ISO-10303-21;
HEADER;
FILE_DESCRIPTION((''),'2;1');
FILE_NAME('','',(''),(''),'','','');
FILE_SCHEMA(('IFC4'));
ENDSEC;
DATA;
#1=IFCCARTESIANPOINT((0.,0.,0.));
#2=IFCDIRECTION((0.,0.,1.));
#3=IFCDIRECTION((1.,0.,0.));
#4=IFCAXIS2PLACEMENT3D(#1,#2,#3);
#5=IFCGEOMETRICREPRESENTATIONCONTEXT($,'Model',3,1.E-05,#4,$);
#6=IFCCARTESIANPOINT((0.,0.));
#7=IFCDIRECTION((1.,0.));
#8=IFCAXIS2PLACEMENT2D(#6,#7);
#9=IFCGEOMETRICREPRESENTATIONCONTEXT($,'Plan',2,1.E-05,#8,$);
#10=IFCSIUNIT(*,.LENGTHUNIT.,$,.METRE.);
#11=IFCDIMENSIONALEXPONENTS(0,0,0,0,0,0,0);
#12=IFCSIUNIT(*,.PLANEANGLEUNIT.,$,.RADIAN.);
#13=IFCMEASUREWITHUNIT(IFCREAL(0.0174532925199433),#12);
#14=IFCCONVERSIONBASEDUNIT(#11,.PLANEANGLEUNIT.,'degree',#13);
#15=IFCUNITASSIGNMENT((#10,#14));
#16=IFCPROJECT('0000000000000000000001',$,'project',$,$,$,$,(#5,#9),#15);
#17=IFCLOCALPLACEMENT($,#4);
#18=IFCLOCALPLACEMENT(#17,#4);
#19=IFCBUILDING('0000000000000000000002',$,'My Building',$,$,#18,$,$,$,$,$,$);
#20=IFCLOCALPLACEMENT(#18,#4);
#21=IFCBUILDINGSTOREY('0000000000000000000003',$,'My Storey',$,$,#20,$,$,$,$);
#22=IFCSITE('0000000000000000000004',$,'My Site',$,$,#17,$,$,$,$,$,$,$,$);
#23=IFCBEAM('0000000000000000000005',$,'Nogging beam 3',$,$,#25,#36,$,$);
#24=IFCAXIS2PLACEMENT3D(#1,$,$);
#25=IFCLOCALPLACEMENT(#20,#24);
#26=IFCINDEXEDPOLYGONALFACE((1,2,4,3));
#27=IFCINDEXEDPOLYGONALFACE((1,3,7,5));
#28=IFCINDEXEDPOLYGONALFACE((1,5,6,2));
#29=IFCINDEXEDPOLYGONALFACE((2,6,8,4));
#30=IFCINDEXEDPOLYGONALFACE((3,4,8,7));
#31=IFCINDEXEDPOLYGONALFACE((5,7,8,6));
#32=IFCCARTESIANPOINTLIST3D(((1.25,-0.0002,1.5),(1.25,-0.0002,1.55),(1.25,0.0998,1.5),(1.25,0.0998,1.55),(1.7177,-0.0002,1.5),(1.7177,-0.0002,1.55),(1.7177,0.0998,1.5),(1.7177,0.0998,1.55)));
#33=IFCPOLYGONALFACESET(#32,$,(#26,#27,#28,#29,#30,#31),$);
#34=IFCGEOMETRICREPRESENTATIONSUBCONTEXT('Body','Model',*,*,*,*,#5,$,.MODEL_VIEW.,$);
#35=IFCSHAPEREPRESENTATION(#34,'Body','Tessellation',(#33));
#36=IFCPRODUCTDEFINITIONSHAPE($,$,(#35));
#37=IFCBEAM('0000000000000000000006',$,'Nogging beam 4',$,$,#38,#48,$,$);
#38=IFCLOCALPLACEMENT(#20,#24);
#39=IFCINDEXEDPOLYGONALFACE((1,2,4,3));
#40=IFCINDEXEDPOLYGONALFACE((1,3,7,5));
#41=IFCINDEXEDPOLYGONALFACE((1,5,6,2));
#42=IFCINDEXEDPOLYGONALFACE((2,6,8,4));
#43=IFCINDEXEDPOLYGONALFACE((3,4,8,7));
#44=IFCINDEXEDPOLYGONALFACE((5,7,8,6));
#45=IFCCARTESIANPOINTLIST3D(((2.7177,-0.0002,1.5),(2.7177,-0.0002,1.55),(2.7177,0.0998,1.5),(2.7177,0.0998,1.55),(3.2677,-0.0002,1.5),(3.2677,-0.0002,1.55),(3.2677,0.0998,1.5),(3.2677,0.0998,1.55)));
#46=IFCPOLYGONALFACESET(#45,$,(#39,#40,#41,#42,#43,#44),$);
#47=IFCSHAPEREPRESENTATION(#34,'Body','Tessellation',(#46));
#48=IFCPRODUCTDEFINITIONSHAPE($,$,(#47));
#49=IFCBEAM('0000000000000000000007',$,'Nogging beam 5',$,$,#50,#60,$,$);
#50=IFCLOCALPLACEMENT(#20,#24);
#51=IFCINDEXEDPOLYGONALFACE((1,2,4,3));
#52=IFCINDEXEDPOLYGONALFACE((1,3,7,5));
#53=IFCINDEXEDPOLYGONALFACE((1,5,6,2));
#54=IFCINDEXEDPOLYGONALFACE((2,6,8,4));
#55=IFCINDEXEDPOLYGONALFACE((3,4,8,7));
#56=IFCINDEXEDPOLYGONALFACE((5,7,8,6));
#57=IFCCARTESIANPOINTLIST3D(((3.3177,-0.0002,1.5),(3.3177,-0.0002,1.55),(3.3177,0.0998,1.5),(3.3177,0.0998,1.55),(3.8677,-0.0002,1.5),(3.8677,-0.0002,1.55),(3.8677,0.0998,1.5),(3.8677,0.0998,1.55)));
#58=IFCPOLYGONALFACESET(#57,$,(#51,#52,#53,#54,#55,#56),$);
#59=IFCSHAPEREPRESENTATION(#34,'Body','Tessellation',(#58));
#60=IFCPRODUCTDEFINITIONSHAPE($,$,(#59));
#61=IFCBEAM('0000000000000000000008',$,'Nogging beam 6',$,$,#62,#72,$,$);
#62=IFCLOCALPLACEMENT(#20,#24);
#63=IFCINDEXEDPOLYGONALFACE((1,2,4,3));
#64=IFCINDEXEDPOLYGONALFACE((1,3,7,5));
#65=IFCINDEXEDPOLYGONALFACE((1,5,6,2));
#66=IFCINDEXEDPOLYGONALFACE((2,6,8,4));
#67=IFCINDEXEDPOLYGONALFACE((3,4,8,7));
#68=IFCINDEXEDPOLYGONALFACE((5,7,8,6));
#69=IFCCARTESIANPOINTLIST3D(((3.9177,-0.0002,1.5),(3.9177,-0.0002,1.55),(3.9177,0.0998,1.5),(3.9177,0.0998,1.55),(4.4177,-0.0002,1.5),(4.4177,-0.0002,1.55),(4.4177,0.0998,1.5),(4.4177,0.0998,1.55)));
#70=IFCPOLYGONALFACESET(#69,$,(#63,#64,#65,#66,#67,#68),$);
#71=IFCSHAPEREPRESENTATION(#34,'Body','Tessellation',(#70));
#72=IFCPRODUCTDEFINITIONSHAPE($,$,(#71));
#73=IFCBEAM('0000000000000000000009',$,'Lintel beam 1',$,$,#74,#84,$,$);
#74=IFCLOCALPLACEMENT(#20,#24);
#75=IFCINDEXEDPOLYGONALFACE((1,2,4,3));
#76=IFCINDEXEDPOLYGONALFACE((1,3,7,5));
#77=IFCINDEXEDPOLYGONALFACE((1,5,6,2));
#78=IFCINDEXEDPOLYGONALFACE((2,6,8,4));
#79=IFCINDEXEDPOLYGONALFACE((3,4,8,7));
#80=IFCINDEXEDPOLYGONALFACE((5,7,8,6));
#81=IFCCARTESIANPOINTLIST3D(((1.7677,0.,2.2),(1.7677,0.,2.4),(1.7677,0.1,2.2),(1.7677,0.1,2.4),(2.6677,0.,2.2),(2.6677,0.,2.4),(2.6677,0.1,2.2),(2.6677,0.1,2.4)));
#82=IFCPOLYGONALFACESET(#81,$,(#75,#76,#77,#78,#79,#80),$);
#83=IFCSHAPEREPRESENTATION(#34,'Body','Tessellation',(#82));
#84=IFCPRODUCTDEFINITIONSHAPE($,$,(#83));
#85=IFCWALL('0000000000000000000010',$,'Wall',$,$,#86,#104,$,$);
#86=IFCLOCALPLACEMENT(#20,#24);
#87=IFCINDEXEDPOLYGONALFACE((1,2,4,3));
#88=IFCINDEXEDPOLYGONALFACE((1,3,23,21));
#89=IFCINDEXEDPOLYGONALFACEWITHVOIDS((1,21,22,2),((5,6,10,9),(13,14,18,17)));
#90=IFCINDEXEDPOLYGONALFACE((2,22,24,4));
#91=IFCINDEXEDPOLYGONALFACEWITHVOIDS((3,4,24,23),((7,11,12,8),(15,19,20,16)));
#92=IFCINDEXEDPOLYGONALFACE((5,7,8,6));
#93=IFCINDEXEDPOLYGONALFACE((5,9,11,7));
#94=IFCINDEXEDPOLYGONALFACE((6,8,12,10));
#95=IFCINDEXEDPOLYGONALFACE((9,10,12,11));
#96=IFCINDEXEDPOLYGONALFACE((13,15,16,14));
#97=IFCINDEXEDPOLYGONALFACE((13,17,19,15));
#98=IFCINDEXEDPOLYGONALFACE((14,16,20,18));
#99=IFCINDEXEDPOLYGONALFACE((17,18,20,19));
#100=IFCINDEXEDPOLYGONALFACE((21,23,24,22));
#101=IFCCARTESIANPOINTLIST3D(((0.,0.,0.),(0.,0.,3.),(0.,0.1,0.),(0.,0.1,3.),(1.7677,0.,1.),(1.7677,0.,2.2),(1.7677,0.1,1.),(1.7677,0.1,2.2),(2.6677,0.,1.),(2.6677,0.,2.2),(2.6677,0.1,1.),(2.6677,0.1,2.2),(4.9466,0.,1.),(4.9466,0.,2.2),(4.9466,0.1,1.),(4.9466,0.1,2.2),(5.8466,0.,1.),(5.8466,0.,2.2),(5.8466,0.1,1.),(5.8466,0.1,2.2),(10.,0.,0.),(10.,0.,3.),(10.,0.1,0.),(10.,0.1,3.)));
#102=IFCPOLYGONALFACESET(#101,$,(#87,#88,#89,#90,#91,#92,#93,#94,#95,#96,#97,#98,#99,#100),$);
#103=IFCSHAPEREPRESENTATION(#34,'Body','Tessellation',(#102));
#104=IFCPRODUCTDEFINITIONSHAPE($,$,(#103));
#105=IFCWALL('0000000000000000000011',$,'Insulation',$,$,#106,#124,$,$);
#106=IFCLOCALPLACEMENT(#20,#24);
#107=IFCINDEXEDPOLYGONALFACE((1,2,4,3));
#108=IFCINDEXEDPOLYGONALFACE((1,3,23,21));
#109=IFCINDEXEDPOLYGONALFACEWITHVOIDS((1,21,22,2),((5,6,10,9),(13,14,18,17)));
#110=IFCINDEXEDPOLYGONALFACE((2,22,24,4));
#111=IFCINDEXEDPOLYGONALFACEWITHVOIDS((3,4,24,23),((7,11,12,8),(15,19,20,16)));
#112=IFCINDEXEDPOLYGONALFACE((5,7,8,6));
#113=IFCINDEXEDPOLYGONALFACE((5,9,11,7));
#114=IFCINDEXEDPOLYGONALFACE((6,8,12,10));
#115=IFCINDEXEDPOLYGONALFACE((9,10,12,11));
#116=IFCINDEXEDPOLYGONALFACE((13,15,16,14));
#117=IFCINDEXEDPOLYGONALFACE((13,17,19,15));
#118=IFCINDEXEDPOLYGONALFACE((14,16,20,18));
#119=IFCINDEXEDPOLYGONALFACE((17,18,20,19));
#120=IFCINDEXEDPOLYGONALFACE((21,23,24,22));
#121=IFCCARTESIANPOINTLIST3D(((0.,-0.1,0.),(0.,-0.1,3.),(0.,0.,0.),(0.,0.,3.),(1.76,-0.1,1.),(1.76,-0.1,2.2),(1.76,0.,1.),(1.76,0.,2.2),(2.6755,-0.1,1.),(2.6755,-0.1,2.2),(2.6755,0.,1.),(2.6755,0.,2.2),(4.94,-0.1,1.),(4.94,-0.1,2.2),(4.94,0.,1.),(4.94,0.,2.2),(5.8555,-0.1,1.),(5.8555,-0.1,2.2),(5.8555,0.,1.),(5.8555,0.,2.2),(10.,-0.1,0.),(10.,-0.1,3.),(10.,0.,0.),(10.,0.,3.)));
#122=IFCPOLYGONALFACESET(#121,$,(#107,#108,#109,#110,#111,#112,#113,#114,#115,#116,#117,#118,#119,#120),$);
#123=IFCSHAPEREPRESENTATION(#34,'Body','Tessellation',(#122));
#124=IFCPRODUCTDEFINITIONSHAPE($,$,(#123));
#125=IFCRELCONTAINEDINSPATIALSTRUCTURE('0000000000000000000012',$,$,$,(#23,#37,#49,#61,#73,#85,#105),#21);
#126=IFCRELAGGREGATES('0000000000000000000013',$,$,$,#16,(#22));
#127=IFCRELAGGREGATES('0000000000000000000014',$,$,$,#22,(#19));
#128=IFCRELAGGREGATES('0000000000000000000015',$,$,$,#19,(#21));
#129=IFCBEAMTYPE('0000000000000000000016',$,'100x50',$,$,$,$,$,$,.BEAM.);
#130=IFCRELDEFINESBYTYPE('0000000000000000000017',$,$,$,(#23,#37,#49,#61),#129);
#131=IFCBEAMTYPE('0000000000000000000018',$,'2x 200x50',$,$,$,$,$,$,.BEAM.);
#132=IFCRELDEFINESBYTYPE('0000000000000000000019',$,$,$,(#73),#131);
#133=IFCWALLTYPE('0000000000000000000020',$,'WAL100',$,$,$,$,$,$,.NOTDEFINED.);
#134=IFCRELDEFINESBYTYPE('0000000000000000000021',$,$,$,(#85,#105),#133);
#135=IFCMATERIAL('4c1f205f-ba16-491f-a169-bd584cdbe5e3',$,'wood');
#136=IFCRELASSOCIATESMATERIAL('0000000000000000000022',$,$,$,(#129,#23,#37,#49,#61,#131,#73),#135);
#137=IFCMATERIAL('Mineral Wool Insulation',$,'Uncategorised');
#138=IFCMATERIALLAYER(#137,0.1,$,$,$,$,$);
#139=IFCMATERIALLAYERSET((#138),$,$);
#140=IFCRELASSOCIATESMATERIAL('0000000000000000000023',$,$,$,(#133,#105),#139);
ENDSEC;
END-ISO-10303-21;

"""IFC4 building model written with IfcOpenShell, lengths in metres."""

from ifc_helpers import new_model, entity, si_unit, converted_unit, frame, origin_with_axes, origin_2d_with_axis, place, context, subcontext, project, spatial, line, indexed_curve, outline, extrude, source, transform, mapped, material, layer, layer_set, layer_usage, material_profile, profile_set, profile_usage, type_object, element, save


model = new_model("IFC4")

# Units and contexts
model_context = context("Model", 3, precision=1e-05, world=origin_with_axes())
plan_context = context("Plan", 2, precision=1e-05, world=origin_2d_with_axis())
body_context = subcontext(model_context, "Body", "Model", "MODEL_VIEW")
ifc_project = project(units=[si_unit("LENGTHUNIT", "METRE"), converted_unit("PLANEANGLEUNIT", "degree", entity("IfcReal", 0.0174532925199433), si_unit("PLANEANGLEUNIT", "RADIAN"), dimensions=[0, 0, 0, 0, 0, 0, 0])], contexts=[model_context, plan_context])

# Site, building, storey
site_placement = place(None, origin_with_axes())
site = spatial("IfcSite", under=ifc_project, at=site_placement, Name="My Site")
building_placement = place(site_placement, origin_with_axes())
building = spatial("IfcBuilding", under=site, at=building_placement, Name="My Building")
storey_placement = place(building_placement, origin_with_axes())
storey = spatial("IfcBuildingStorey", under=building, at=storey_placement, Name="My Storey")

# Shared definitions
ifc_material_1 = material(Name="4c1f205f-ba16-491f-a169-bd584cdbe5e3", Category="wood")

# Beams
ifc_material_profile_1 = material_profile(ifc_material_1, outline(indexed_curve([(-0.05, 0.025), (0.05, 0.025), (0.05, -0.025), (-0.05, -0.025), (-0.05, 0.025)])))
ifc_profile_set_1 = profile_set([ifc_material_profile_1])
beam_type_1 = type_object("IfcBeamType", Name="100x50", PredefinedType="BEAM", material=ifc_profile_set_1)
ifc_profile_usage_1 = profile_usage(ifc_profile_set_1, cardinal=5)
beam_1_placement = place(storey_placement, frame((1.25, 0.0498, 1.525), z_axis=(1.0, -0.000001, 0.000001), x_axis=(0.000001, 1.0, 0.0)))
element("IfcBeam", 1, at=beam_1_placement, inside=storey, type_object=beam_type_1, material=ifc_profile_usage_1, Name="Nogging beam 3", context=body_context, shape_type="SweptSolid", body=[
    extrude(outline(indexed_curve([(-0.05, 0.025), (0.05, 0.025), (0.05, -0.025), (-0.05, -0.025), (-0.05, 0.025)])), origin_with_axes(), (0.0, 0.0, 1.0), 0.4677),
])
ifc_profile_usage_2 = profile_usage(ifc_profile_set_1, cardinal=5)
beam_2_placement = place(storey_placement, frame((2.7177, 0.0498, 1.525), z_axis=(1.0, -0.000001, 0.000001), x_axis=(0.000001, 1.0, 0.0)))
element("IfcBeam", 2, at=beam_2_placement, inside=storey, type_object=beam_type_1, material=ifc_profile_usage_2, Name="Nogging beam 4", context=body_context, shape_type="SweptSolid", body=[
    extrude(outline(indexed_curve([(-0.05, 0.025), (0.05, 0.025), (0.05, -0.025), (-0.05, -0.025), (-0.05, 0.025)])), origin_with_axes(), (0.0, 0.0, 1.0), 0.55),
])
ifc_profile_usage_3 = profile_usage(ifc_profile_set_1, cardinal=5)
beam_3_placement = place(storey_placement, frame((3.3177, 0.0498, 1.525), z_axis=(1.0, -0.000001, 0.000001), x_axis=(0.000001, 1.0, 0.0)))
element("IfcBeam", 3, at=beam_3_placement, inside=storey, type_object=beam_type_1, material=ifc_profile_usage_3, Name="Nogging beam 5", context=body_context, shape_type="SweptSolid", body=[
    extrude(outline(indexed_curve([(-0.05, 0.025), (0.05, 0.025), (0.05, -0.025), (-0.05, -0.025), (-0.05, 0.025)])), origin_with_axes(), (0.0, 0.0, 1.0), 0.55),
])
ifc_profile_usage_4 = profile_usage(ifc_profile_set_1, cardinal=5)
beam_4_placement = place(storey_placement, frame((3.9177, 0.0498, 1.525), z_axis=(1.0, -0.000001, 0.000001), x_axis=(0.000001, 1.0, 0.0)))
element("IfcBeam", 4, at=beam_4_placement, inside=storey, type_object=beam_type_1, material=ifc_profile_usage_4, Name="Nogging beam 6", context=body_context, shape_type="SweptSolid", body=[
    extrude(outline(indexed_curve([(-0.05, 0.025), (0.05, 0.025), (0.05, -0.025), (-0.05, -0.025), (-0.05, 0.025)])), origin_with_axes(), (0.0, 0.0, 1.0), 0.5),
])
ifc_material_profile_2 = material_profile(ifc_material_1, outline(indexed_curve([(-0.1, 0.05), (0.1, 0.05), (0.1, -0.05), (-0.1, -0.05), (-0.1, 0.05)])))
ifc_profile_set_2 = profile_set([ifc_material_profile_2])
ifc_profile_usage_5 = profile_usage(ifc_profile_set_2, cardinal=5)
beam_type_2 = type_object("IfcBeamType", Name="2x 200x50", PredefinedType="BEAM", material=ifc_profile_set_2)
beam_5_placement = place(storey_placement, frame((1.7677, 0.05, 2.3), z_axis=(1.0, 0.0, 0.0), x_axis=(0.0, 0.0, 1.0)))
element("IfcBeam", 5, at=beam_5_placement, inside=storey, type_object=beam_type_2, material=ifc_profile_usage_5, Name="Lintel beam 1", context=body_context, shape_type="SweptSolid", body=[
    extrude(outline(indexed_curve([(-0.1, 0.05), (0.1, 0.05), (0.1, -0.05), (-0.1, -0.05), (-0.1, 0.05)])), origin_with_axes(), (0.0, 0.0, 1.0), 0.9),
])

# Walls, openings
ifc_material_2 = material(Name="Mineral Wool Insulation", Category="Uncategorised")
ifc_layer = layer(ifc_material_2, 0.1)
ifc_layer_set = layer_set([ifc_layer])
wall_type = type_object("IfcWallType", Name="WAL100", PredefinedType="NOTDEFINED", material=ifc_layer_set)
wall_1_placement = place(storey_placement, origin_with_axes())
wall_1 = element("IfcWall", 6, at=wall_1_placement, inside=storey, type_object=wall_type, Name="Wall", context=body_context, shape_type="SweptSolid", body=[
    extrude(outline(indexed_curve([(0.0, 0.0), (0.0, 0.1), (10.0, 0.1), (10.0, 0.0), (0.0, 0.0)], self_intersect=False)), origin_with_axes(), (0.0, 0.0, 1.0), 3.0),
])
shared_shape = source(origin_with_axes(), body_context, "Body", "SweptSolid", [
    extrude(outline(indexed_curve([(0.0, 0.0), (0.9, 0.0), (0.9, 1.2), (0.0, 1.2)], segments=[line(1, 2, 3, 4, 1)])), frame((0.0, -0.6, 0.0), z_axis=(0.0, -1.0, 0.0), x_axis=(1.0, 0.0, 0.0)), (0.0, 0.0, -1.0), 1.2),
])
opening_1_placement = place(wall_1_placement, frame((1.7677, 0.0, 1.0), z_axis=(0.0, 0.0, 1.0), x_axis=(1.0, 0.0, 0.0)))
element("IfcOpeningElement", 7, at=opening_1_placement, cuts=wall_1, PredefinedType="OPENING", context=body_context, shape_type="MappedRepresentation", body=[
    mapped(shared_shape, transform((0.0, 0.0, 0.0), x_axis=(1.0, 0.0, 0.0), y_axis=(0.0, 1.0, 0.0), z_axis=(0.0, 0.0, 1.0), scale=1.0)),
])
opening_2_placement = place(wall_1_placement, frame((4.9466, 0.0, 1.0), z_axis=(0.0, 0.0, 1.0), x_axis=(1.0, 0.0, 0.0)))
element("IfcOpeningElement", 8, at=opening_2_placement, cuts=wall_1, PredefinedType="OPENING", context=body_context, shape_type="MappedRepresentation", body=[
    mapped(shared_shape, transform((0.0, 0.0, 0.0), x_axis=(1.0, 0.0, 0.0), y_axis=(0.0, 1.0, 0.0), z_axis=(0.0, 0.0, 1.0), scale=1.0)),
])
ifc_layer_usage = layer_usage(ifc_layer_set, "AXIS2", "POSITIVE", 0.0)
wall_2_placement = place(storey_placement, frame((0.0, -0.1, 0.0), z_axis=(0.0, 0.0, 1.0), x_axis=(1.0, 0.0, 0.0)))
wall_2 = element("IfcWall", 9, at=wall_2_placement, inside=storey, type_object=wall_type, material=ifc_layer_usage, Name="Insulation", context=body_context, shape_type="SweptSolid", body=[
    extrude(outline(indexed_curve([(0.0, 0.0), (0.0, 0.1), (10.0, 0.1), (10.0, 0.0)], segments=[line(1, 2, 3, 4, 1)])), origin_with_axes(), (0.0, 0.0, 1.0), 3.0),
])
opening_3_placement = place(wall_2_placement, frame((0.0, 0.1, 0.0), z_axis=(0.0, 0.0, 1.0), x_axis=(1.0, 0.0, 0.0)))
element("IfcOpeningElement", 10, at=opening_3_placement, cuts=wall_2, PredefinedType="OPENING", context=body_context, shape_type="SweptSolid", body=[
    extrude(outline(indexed_curve([(0.0, 0.0), (0.9155, 0.0), (0.9155, 0.5), (0.0, 0.5), (0.0, 0.0)])), frame((1.76, -0.269, 1.0), z_axis=(0.0, 0.0, 1.0), x_axis=(1.0, 0.0, 0.0)), (0.0, 0.0, 1.0), 1.2),
])
opening_4_placement = place(wall_2_placement, frame((0.0, 0.1, 0.0), z_axis=(0.0, 0.0, 1.0), x_axis=(1.0, 0.0, 0.0)))
element("IfcOpeningElement", 11, at=opening_4_placement, cuts=wall_2, PredefinedType="OPENING", context=body_context, shape_type="SweptSolid", body=[
    extrude(outline(indexed_curve([(0.0, 0.0), (0.9155, 0.0), (0.9155, 0.5), (0.0, 0.5), (0.0, 0.0)])), frame((4.94, -0.269, 1.0), z_axis=(0.0, 0.0, 1.0), x_axis=(1.0, 0.0, 0.0)), (0.0, 0.0, 1.0), 1.2),
])

save(model, "model.ifc")
